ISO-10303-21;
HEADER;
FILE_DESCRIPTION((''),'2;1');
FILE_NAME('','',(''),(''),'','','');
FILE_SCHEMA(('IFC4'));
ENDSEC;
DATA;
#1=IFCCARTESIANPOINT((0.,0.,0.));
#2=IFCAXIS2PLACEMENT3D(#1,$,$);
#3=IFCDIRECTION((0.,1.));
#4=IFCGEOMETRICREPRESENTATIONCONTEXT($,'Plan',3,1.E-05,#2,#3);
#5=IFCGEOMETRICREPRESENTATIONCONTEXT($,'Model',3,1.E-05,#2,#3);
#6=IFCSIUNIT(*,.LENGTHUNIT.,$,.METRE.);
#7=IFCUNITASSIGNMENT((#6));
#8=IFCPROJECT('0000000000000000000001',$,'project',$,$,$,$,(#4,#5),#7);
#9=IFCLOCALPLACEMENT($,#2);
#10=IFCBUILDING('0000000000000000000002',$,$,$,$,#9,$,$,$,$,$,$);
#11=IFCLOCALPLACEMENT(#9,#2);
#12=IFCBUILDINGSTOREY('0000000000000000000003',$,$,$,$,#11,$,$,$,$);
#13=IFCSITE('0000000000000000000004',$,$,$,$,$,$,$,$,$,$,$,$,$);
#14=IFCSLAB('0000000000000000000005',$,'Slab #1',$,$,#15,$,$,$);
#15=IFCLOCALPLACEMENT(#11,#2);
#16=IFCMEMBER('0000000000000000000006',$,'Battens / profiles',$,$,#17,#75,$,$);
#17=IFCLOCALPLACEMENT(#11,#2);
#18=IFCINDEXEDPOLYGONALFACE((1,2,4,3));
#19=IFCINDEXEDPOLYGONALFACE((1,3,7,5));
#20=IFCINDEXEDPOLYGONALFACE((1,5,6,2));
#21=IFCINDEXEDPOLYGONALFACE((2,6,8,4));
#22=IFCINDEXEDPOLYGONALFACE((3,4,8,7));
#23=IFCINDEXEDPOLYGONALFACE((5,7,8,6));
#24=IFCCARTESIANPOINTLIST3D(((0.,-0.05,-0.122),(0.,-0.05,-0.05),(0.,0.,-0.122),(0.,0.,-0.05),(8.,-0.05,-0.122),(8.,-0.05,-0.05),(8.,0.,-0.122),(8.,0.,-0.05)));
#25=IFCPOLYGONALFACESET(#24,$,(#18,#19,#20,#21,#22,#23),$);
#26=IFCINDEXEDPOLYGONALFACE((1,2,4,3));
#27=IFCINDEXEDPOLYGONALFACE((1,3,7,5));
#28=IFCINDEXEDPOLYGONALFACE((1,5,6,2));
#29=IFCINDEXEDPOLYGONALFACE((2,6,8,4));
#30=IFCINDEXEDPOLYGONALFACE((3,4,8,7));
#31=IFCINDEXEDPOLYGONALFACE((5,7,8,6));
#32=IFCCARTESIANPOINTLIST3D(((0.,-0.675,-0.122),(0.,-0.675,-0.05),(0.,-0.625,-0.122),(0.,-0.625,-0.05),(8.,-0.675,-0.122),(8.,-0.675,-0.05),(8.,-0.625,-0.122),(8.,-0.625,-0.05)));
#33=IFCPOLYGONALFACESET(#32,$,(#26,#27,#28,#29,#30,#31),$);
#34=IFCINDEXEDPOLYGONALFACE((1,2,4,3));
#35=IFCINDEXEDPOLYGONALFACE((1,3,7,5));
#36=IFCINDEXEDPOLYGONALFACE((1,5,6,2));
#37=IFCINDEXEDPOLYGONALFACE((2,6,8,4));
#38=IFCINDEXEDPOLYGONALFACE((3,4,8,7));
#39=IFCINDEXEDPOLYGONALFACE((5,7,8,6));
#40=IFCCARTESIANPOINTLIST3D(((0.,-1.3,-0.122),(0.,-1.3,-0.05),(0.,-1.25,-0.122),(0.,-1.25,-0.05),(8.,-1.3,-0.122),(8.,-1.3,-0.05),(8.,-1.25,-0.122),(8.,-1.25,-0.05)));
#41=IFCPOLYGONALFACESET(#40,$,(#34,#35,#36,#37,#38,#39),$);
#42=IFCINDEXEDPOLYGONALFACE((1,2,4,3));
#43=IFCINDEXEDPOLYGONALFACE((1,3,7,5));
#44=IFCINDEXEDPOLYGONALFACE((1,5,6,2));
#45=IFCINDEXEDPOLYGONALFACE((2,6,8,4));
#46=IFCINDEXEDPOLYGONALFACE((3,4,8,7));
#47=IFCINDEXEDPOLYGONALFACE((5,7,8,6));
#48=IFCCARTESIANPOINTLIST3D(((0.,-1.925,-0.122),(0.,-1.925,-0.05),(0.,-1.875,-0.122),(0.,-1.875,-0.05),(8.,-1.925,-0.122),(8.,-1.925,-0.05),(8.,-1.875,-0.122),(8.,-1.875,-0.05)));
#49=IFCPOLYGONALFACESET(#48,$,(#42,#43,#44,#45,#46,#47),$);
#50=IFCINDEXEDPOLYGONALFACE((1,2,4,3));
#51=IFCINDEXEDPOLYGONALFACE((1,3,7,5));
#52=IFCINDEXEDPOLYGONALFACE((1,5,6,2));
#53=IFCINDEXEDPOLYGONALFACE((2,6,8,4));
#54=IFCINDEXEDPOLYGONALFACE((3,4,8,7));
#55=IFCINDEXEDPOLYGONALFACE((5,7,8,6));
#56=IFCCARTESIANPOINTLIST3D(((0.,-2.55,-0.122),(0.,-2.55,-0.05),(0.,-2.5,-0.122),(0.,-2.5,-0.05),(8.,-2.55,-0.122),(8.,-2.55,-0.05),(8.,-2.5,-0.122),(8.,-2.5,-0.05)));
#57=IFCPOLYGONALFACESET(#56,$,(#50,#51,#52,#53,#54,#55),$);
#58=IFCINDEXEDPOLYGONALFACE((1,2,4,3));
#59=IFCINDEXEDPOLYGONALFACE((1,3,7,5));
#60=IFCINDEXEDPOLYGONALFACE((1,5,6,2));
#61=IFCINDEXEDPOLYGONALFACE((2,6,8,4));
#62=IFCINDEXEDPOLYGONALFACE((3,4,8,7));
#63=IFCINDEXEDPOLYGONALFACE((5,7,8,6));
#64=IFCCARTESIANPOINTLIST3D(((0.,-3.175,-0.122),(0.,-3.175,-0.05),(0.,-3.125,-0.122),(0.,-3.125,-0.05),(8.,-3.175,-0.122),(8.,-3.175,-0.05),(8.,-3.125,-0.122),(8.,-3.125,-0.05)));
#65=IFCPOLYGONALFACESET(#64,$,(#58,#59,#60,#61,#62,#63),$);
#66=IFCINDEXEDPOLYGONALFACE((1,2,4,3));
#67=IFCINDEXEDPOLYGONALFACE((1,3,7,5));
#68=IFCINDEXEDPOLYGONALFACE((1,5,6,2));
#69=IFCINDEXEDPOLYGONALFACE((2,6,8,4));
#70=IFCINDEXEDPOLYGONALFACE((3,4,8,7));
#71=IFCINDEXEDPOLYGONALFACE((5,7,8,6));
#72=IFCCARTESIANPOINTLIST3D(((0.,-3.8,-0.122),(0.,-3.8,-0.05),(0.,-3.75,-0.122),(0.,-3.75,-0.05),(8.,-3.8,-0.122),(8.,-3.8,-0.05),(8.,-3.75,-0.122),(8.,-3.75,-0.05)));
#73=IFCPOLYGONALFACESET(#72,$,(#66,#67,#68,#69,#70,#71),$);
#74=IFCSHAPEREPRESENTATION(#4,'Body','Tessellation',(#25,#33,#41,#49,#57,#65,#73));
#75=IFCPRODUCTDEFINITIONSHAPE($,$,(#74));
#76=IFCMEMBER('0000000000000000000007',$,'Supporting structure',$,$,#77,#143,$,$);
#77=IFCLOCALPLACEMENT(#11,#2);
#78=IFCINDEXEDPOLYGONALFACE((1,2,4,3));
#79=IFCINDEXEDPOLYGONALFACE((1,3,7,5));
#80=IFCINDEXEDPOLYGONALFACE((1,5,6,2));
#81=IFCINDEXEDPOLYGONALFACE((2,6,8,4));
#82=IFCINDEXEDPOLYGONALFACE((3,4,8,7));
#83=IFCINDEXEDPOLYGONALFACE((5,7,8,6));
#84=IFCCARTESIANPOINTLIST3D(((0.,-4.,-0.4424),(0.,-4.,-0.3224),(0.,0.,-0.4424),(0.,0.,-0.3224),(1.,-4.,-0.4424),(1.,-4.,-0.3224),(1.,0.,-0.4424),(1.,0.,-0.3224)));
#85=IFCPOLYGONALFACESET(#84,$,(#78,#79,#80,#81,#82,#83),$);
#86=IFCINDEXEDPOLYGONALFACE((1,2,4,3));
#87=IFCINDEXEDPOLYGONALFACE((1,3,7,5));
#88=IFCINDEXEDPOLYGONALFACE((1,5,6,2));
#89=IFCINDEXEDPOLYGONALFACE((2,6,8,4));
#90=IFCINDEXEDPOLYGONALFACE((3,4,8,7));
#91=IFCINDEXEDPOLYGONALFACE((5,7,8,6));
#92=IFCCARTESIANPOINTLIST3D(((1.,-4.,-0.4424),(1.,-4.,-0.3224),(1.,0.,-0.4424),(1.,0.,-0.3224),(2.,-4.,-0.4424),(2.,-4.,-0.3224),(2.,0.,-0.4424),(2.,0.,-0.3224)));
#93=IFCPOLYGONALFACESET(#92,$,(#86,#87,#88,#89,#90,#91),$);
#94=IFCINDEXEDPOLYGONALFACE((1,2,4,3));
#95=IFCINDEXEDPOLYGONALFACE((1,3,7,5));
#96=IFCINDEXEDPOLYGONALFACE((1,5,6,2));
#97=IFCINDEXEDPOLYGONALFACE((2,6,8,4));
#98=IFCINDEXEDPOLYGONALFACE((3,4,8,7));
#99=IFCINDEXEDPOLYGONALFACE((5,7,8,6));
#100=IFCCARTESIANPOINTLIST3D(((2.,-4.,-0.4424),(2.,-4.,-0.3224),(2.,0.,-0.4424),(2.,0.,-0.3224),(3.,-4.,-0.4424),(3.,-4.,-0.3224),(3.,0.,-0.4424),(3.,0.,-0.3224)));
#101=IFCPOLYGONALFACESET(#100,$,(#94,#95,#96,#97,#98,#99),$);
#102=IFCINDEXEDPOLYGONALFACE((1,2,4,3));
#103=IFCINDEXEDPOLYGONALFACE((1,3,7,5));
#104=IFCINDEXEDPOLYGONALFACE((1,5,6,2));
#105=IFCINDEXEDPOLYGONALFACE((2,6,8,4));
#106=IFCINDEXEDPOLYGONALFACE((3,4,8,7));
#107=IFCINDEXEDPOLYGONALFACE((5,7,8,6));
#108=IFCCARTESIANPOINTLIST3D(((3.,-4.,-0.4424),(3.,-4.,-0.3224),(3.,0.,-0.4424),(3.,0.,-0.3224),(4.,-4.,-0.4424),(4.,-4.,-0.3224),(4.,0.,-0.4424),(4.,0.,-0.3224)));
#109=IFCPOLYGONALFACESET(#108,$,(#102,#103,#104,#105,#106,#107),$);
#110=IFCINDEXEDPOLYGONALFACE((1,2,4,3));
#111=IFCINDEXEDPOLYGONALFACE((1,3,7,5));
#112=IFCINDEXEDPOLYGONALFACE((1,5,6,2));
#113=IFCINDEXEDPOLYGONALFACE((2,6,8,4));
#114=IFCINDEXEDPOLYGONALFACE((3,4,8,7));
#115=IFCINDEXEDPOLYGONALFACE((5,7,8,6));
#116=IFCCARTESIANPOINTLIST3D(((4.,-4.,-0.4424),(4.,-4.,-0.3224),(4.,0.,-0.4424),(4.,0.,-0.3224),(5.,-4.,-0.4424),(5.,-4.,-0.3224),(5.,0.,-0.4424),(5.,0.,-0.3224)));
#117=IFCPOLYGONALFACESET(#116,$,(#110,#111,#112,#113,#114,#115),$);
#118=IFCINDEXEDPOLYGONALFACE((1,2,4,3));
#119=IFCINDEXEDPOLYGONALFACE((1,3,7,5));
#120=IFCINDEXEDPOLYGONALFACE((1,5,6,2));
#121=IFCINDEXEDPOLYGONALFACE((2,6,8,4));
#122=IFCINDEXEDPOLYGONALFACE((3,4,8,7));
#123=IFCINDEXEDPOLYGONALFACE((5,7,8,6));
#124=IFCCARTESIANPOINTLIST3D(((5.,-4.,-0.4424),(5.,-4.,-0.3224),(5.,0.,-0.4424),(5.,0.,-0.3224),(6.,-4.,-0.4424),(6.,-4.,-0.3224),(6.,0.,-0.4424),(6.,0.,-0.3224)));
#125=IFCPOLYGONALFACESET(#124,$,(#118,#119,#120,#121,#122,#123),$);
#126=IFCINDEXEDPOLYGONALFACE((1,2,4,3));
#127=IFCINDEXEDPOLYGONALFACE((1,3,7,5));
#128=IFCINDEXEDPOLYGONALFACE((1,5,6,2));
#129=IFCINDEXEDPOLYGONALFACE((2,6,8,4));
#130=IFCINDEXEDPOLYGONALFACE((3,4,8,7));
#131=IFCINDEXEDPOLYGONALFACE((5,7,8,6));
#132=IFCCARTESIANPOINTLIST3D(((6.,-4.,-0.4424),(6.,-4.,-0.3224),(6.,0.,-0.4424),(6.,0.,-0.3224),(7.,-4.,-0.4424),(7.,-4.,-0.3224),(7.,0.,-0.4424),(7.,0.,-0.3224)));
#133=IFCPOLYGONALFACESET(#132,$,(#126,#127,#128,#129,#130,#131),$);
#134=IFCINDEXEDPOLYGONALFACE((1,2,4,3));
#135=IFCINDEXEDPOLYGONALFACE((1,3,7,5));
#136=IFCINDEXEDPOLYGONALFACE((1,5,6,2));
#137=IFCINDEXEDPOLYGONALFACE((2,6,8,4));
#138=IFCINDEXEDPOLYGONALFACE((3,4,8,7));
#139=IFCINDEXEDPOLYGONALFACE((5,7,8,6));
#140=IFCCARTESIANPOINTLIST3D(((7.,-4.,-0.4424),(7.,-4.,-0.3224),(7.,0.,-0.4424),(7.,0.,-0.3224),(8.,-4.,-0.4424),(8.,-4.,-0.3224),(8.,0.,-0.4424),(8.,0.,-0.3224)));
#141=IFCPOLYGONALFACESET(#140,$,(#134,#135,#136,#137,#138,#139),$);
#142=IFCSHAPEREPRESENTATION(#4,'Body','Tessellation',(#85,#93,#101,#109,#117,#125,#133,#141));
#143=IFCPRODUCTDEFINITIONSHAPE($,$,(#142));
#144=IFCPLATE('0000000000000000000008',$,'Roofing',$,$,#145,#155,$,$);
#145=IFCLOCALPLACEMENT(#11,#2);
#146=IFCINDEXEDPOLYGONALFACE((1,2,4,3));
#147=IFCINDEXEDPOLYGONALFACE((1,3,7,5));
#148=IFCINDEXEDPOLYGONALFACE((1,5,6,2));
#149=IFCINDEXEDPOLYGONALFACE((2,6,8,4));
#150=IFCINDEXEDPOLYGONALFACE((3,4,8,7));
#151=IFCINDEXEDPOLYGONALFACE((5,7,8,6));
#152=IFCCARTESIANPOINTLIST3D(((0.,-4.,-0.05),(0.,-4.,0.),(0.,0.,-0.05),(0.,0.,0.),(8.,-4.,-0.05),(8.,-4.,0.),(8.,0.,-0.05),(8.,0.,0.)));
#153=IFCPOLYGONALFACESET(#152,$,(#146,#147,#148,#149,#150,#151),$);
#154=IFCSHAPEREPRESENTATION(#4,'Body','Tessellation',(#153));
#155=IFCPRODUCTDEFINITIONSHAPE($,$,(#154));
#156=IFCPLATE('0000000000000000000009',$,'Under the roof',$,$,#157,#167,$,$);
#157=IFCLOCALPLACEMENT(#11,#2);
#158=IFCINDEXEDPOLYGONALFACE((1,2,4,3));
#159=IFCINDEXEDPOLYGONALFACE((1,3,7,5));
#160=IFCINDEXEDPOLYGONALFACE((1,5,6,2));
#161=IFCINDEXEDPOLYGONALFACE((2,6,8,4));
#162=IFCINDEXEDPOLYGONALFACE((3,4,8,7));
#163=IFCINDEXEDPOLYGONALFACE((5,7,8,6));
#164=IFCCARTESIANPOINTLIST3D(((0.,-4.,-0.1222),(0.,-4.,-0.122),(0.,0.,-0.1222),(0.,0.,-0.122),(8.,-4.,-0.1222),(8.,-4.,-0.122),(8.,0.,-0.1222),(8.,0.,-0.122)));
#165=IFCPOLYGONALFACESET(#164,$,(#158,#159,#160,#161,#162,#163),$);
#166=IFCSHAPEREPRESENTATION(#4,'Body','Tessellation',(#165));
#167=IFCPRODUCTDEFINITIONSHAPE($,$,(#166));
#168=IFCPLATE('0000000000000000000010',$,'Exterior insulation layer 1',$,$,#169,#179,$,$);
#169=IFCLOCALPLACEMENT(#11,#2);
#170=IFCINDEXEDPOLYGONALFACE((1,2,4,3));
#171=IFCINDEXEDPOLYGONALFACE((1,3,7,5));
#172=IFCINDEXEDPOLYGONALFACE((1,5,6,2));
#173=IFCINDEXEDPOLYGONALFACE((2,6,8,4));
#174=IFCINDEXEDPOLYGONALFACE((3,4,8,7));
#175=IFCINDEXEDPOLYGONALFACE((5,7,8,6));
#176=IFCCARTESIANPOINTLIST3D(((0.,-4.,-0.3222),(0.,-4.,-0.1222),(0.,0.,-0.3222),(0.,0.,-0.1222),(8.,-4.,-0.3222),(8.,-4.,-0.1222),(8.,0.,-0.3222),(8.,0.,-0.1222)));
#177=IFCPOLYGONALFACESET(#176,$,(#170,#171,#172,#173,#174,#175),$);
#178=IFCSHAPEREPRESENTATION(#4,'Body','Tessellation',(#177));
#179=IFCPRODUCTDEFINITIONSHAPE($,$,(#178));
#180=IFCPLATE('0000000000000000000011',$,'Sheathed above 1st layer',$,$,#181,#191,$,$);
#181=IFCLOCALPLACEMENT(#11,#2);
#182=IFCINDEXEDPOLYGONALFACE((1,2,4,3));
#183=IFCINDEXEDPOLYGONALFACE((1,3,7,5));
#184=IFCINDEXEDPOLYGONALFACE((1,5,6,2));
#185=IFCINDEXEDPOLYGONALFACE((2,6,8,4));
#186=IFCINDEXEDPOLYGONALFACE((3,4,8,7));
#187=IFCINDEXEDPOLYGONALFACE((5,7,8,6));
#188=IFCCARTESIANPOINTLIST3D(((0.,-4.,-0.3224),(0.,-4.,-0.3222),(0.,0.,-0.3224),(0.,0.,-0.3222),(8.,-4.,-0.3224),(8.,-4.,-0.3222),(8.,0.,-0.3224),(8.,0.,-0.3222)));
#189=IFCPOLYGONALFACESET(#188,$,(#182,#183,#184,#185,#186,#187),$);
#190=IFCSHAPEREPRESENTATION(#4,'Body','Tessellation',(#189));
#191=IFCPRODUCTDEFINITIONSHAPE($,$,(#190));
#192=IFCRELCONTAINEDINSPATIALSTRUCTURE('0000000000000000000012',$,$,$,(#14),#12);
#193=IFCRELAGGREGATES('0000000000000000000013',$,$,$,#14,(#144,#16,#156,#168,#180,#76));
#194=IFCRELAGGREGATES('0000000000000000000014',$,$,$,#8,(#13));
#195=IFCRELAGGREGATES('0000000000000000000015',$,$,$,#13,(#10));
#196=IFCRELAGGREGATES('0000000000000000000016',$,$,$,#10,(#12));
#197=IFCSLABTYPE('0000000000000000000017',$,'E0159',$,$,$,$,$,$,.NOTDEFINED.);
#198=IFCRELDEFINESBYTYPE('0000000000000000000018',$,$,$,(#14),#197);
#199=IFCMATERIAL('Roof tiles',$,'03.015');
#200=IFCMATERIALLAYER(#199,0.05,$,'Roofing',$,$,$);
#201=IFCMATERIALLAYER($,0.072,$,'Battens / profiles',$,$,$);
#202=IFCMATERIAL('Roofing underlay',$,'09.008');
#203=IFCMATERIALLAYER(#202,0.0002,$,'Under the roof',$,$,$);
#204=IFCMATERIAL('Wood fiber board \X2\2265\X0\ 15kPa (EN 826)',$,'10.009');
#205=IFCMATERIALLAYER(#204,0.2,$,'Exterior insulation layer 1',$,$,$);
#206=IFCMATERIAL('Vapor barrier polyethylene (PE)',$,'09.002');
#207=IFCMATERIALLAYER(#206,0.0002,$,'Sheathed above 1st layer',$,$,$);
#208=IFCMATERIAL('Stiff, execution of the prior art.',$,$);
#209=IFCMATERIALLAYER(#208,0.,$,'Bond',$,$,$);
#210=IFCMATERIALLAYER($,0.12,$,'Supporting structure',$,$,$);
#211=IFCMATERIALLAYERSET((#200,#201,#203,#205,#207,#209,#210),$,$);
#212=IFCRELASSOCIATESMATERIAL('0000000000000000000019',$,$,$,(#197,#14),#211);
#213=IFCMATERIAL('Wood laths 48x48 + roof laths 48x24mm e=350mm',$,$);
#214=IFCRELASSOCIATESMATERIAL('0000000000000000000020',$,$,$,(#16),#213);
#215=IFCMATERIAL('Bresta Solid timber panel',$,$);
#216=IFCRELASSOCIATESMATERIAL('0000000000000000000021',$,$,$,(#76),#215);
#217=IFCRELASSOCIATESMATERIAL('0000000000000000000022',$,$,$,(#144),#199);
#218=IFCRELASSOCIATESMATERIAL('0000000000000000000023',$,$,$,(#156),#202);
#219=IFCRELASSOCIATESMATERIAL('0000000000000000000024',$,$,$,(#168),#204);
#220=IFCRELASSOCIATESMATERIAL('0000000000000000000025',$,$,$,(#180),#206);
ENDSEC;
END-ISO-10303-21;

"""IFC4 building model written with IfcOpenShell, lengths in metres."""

from ifc_helpers import new_model, si_unit, direction, frame, frame_2d, origin, origin_with_axes, place, context, project, spatial, rectangle, extrude, material, layer, layer_set, type_object, element, aggregate, save


model = new_model("IFC4")

# Units and contexts
plan_context = context("Plan", 3, precision=1e-05, world=origin(), true_north=direction((0.0, 1.0)))
model_context = context("Model", 3, precision=1e-05, world=origin(), true_north=direction((0.0, 1.0)))
ifc_project = project(units=[si_unit("LENGTHUNIT", "METRE")], contexts=[plan_context, model_context])

# Site, building, storey
site = spatial("IfcSite", under=ifc_project)
building_placement = place(None, origin())
building = spatial("IfcBuilding", under=site, at=building_placement)
storey_placement = place(building_placement, origin())
storey = spatial("IfcBuildingStorey", under=building, at=storey_placement)

# Slab, members, plates
ifc_material_1 = material(Name="Roof tiles", Category="03.015")
ifc_layer_1 = layer(ifc_material_1, 0.05, Name="Roofing")
ifc_layer_2 = layer(None, 0.072, Name="Battens / profiles")
ifc_material_2 = material(Name="Roofing underlay", Category="09.008")
ifc_layer_3 = layer(ifc_material_2, 0.0002, Name="Under the roof")
ifc_material_3 = material(Name="Wood fiber board ≥ 15kPa (EN 826)", Category="10.009")
ifc_layer_4 = layer(ifc_material_3, 0.2, Name="Exterior insulation layer 1")
ifc_material_4 = material(Name="Vapor barrier polyethylene (PE)", Category="09.002")
ifc_layer_5 = layer(ifc_material_4, 0.0002, Name="Sheathed above 1st layer")
ifc_material_5 = material(Name="Stiff, execution of the prior art.")
ifc_layer_6 = layer(ifc_material_5, 0.0, Name="Bond")
ifc_layer_7 = layer(None, 0.12, Name="Supporting structure")
ifc_layer_set = layer_set([ifc_layer_1, ifc_layer_2, ifc_layer_3, ifc_layer_4, ifc_layer_5, ifc_layer_6, ifc_layer_7])
slab_type = type_object("IfcSlabType", Name="E0159", PredefinedType="NOTDEFINED", material=ifc_layer_set)
slab_placement = place(None, frame((0.0, 0.0, 0.0), z_axis=(0.0, 0.0, -1.0), x_axis=(1.0, 0.0, 0.0)))
slab = element("IfcSlab", 1, at=slab_placement, inside=storey, type_object=slab_type, material=ifc_layer_set, Name="Slab #1")
ifc_material_6 = material(Name="Wood laths 48x48 + roof laths 48x24mm e=350mm")
member_1_placement = place(slab_placement, origin())
member_1 = element("IfcMember", 2, at=member_1_placement, material=ifc_material_6, Name="Battens / profiles", context=plan_context, shape_type="SweptSolid", body=[
    extrude(rectangle(XDim=0.05, YDim=0.072, at=frame_2d((0.025, 0.036), x_axis=(1.0, 0.0))), frame((0.0, 0.0, 0.05), z_axis=(1.0, 0.0, 0.0), x_axis=(0.0, 1.0, 0.0)), (0.0, 0.0, 1.0), 8.0),
    extrude(rectangle(XDim=0.05, YDim=0.072, at=frame_2d((0.025, 0.036), x_axis=(1.0, 0.0))), frame((0.0, 0.625, 0.05), z_axis=(1.0, 0.0, 0.0), x_axis=(0.0, 1.0, 0.0)), (0.0, 0.0, 1.0), 8.0),
    extrude(rectangle(XDim=0.05, YDim=0.072, at=frame_2d((0.025, 0.036), x_axis=(1.0, 0.0))), frame((0.0, 1.25, 0.05), z_axis=(1.0, 0.0, 0.0), x_axis=(0.0, 1.0, 0.0)), (0.0, 0.0, 1.0), 8.0),
    extrude(rectangle(XDim=0.05, YDim=0.072, at=frame_2d((0.025, 0.036), x_axis=(1.0, 0.0))), frame((0.0, 1.875, 0.05), z_axis=(1.0, 0.0, 0.0), x_axis=(0.0, 1.0, 0.0)), (0.0, 0.0, 1.0), 8.0),
    extrude(rectangle(XDim=0.05, YDim=0.072, at=frame_2d((0.025, 0.036), x_axis=(1.0, 0.0))), frame((0.0, 2.5, 0.05), z_axis=(1.0, 0.0, 0.0), x_axis=(0.0, 1.0, 0.0)), (0.0, 0.0, 1.0), 8.0),
    extrude(rectangle(XDim=0.05, YDim=0.072, at=frame_2d((0.025, 0.036), x_axis=(1.0, 0.0))), frame((0.0, 3.125, 0.05), z_axis=(1.0, 0.0, 0.0), x_axis=(0.0, 1.0, 0.0)), (0.0, 0.0, 1.0), 8.0),
    extrude(rectangle(XDim=0.05, YDim=0.072, at=frame_2d((0.025, 0.036), x_axis=(1.0, 0.0))), frame((0.0, 3.75, 0.05), z_axis=(1.0, 0.0, 0.0), x_axis=(0.0, 1.0, 0.0)), (0.0, 0.0, 1.0), 8.0),
])
ifc_material_7 = material(Name="Bresta Solid timber panel")
member_2_placement = place(slab_placement, origin())
member_2 = element("IfcMember", 3, at=member_2_placement, material=ifc_material_7, Name="Supporting structure", context=plan_context, shape_type="SweptSolid", body=[
    extrude(rectangle(XDim=1.0, YDim=0.12, at=frame_2d((0.5, 0.06), x_axis=(1.0, 0.0))), frame((0.0, 4.0, 0.3224), z_axis=(0.0, -1.0, 0.0), x_axis=(1.0, 0.0, 0.0)), (0.0, 0.0, 1.0), 4.0),
    extrude(rectangle(XDim=1.0, YDim=0.12, at=frame_2d((0.5, 0.06), x_axis=(1.0, 0.0))), frame((1.0, 4.0, 0.3224), z_axis=(0.0, -1.0, 0.0), x_axis=(1.0, 0.0, 0.0)), (0.0, 0.0, 1.0), 4.0),
    extrude(rectangle(XDim=1.0, YDim=0.12, at=frame_2d((0.5, 0.06), x_axis=(1.0, 0.0))), frame((2.0, 4.0, 0.3224), z_axis=(0.0, -1.0, 0.0), x_axis=(1.0, 0.0, 0.0)), (0.0, 0.0, 1.0), 4.0),
    extrude(rectangle(XDim=1.0, YDim=0.12, at=frame_2d((0.5, 0.06), x_axis=(1.0, 0.0))), frame((3.0, 4.0, 0.3224), z_axis=(0.0, -1.0, 0.0), x_axis=(1.0, 0.0, 0.0)), (0.0, 0.0, 1.0), 4.0),
    extrude(rectangle(XDim=1.0, YDim=0.12, at=frame_2d((0.5, 0.06), x_axis=(1.0, 0.0))), frame((4.0, 4.0, 0.3224), z_axis=(0.0, -1.0, 0.0), x_axis=(1.0, 0.0, 0.0)), (0.0, 0.0, 1.0), 4.0),
    extrude(rectangle(XDim=1.0, YDim=0.12, at=frame_2d((0.5, 0.06), x_axis=(1.0, 0.0))), frame((5.0, 4.0, 0.3224), z_axis=(0.0, -1.0, 0.0), x_axis=(1.0, 0.0, 0.0)), (0.0, 0.0, 1.0), 4.0),
    extrude(rectangle(XDim=1.0, YDim=0.12, at=frame_2d((0.5, 0.06), x_axis=(1.0, 0.0))), frame((6.0, 4.0, 0.3224), z_axis=(0.0, -1.0, 0.0), x_axis=(1.0, 0.0, 0.0)), (0.0, 0.0, 1.0), 4.0),
    extrude(rectangle(XDim=1.0, YDim=0.12, at=frame_2d((0.5, 0.06), x_axis=(1.0, 0.0))), frame((7.0, 4.0, 0.3224), z_axis=(0.0, -1.0, 0.0), x_axis=(1.0, 0.0, 0.0)), (0.0, 0.0, 1.0), 4.0),
])
plate_1_placement = place(slab_placement, origin())
plate_1 = element("IfcPlate", 4, at=plate_1_placement, material=ifc_material_1, Name="Roofing", context=plan_context, shape_type="SweptSolid", body=[
    extrude(rectangle(XDim=8.0, YDim=4.0, at=frame_2d((4.0, 2.0), x_axis=(1.0, 0.0))), origin_with_axes(), (0.0, 0.0, 1.0), 0.05),
])
plate_2_placement = place(slab_placement, origin())
plate_2 = element("IfcPlate", 5, at=plate_2_placement, material=ifc_material_2, Name="Under the roof", context=plan_context, shape_type="SweptSolid", body=[
    extrude(rectangle(XDim=8.0, YDim=4.0, at=frame_2d((4.0, 2.0), x_axis=(1.0, 0.0))), frame((0.0, 0.0, 0.122), z_axis=(0.0, 0.0, 1.0), x_axis=(1.0, 0.0, 0.0)), (0.0, 0.0, 1.0), 0.0002),
])
plate_3_placement = place(slab_placement, origin())
plate_3 = element("IfcPlate", 6, at=plate_3_placement, material=ifc_material_3, Name="Exterior insulation layer 1", context=plan_context, shape_type="SweptSolid", body=[
    extrude(rectangle(XDim=8.0, YDim=4.0, at=frame_2d((4.0, 2.0), x_axis=(1.0, 0.0))), frame((0.0, 0.0, 0.1222), z_axis=(0.0, 0.0, 1.0), x_axis=(1.0, 0.0, 0.0)), (0.0, 0.0, 1.0), 0.2),
])
plate_4_placement = place(slab_placement, origin())
plate_4 = element("IfcPlate", 7, at=plate_4_placement, material=ifc_material_4, Name="Sheathed above 1st layer", context=plan_context, shape_type="SweptSolid", body=[
    extrude(rectangle(XDim=8.0, YDim=4.0, at=frame_2d((4.0, 2.0), x_axis=(1.0, 0.0))), frame((0.0, 0.0, 0.3222), z_axis=(0.0, 0.0, 1.0), x_axis=(1.0, 0.0, 0.0)), (0.0, 0.0, 1.0), 0.0002),
])
aggregate(slab, [plate_1, member_1, plate_2, plate_3, plate_4, member_2])

save(model, "model.ifc")
